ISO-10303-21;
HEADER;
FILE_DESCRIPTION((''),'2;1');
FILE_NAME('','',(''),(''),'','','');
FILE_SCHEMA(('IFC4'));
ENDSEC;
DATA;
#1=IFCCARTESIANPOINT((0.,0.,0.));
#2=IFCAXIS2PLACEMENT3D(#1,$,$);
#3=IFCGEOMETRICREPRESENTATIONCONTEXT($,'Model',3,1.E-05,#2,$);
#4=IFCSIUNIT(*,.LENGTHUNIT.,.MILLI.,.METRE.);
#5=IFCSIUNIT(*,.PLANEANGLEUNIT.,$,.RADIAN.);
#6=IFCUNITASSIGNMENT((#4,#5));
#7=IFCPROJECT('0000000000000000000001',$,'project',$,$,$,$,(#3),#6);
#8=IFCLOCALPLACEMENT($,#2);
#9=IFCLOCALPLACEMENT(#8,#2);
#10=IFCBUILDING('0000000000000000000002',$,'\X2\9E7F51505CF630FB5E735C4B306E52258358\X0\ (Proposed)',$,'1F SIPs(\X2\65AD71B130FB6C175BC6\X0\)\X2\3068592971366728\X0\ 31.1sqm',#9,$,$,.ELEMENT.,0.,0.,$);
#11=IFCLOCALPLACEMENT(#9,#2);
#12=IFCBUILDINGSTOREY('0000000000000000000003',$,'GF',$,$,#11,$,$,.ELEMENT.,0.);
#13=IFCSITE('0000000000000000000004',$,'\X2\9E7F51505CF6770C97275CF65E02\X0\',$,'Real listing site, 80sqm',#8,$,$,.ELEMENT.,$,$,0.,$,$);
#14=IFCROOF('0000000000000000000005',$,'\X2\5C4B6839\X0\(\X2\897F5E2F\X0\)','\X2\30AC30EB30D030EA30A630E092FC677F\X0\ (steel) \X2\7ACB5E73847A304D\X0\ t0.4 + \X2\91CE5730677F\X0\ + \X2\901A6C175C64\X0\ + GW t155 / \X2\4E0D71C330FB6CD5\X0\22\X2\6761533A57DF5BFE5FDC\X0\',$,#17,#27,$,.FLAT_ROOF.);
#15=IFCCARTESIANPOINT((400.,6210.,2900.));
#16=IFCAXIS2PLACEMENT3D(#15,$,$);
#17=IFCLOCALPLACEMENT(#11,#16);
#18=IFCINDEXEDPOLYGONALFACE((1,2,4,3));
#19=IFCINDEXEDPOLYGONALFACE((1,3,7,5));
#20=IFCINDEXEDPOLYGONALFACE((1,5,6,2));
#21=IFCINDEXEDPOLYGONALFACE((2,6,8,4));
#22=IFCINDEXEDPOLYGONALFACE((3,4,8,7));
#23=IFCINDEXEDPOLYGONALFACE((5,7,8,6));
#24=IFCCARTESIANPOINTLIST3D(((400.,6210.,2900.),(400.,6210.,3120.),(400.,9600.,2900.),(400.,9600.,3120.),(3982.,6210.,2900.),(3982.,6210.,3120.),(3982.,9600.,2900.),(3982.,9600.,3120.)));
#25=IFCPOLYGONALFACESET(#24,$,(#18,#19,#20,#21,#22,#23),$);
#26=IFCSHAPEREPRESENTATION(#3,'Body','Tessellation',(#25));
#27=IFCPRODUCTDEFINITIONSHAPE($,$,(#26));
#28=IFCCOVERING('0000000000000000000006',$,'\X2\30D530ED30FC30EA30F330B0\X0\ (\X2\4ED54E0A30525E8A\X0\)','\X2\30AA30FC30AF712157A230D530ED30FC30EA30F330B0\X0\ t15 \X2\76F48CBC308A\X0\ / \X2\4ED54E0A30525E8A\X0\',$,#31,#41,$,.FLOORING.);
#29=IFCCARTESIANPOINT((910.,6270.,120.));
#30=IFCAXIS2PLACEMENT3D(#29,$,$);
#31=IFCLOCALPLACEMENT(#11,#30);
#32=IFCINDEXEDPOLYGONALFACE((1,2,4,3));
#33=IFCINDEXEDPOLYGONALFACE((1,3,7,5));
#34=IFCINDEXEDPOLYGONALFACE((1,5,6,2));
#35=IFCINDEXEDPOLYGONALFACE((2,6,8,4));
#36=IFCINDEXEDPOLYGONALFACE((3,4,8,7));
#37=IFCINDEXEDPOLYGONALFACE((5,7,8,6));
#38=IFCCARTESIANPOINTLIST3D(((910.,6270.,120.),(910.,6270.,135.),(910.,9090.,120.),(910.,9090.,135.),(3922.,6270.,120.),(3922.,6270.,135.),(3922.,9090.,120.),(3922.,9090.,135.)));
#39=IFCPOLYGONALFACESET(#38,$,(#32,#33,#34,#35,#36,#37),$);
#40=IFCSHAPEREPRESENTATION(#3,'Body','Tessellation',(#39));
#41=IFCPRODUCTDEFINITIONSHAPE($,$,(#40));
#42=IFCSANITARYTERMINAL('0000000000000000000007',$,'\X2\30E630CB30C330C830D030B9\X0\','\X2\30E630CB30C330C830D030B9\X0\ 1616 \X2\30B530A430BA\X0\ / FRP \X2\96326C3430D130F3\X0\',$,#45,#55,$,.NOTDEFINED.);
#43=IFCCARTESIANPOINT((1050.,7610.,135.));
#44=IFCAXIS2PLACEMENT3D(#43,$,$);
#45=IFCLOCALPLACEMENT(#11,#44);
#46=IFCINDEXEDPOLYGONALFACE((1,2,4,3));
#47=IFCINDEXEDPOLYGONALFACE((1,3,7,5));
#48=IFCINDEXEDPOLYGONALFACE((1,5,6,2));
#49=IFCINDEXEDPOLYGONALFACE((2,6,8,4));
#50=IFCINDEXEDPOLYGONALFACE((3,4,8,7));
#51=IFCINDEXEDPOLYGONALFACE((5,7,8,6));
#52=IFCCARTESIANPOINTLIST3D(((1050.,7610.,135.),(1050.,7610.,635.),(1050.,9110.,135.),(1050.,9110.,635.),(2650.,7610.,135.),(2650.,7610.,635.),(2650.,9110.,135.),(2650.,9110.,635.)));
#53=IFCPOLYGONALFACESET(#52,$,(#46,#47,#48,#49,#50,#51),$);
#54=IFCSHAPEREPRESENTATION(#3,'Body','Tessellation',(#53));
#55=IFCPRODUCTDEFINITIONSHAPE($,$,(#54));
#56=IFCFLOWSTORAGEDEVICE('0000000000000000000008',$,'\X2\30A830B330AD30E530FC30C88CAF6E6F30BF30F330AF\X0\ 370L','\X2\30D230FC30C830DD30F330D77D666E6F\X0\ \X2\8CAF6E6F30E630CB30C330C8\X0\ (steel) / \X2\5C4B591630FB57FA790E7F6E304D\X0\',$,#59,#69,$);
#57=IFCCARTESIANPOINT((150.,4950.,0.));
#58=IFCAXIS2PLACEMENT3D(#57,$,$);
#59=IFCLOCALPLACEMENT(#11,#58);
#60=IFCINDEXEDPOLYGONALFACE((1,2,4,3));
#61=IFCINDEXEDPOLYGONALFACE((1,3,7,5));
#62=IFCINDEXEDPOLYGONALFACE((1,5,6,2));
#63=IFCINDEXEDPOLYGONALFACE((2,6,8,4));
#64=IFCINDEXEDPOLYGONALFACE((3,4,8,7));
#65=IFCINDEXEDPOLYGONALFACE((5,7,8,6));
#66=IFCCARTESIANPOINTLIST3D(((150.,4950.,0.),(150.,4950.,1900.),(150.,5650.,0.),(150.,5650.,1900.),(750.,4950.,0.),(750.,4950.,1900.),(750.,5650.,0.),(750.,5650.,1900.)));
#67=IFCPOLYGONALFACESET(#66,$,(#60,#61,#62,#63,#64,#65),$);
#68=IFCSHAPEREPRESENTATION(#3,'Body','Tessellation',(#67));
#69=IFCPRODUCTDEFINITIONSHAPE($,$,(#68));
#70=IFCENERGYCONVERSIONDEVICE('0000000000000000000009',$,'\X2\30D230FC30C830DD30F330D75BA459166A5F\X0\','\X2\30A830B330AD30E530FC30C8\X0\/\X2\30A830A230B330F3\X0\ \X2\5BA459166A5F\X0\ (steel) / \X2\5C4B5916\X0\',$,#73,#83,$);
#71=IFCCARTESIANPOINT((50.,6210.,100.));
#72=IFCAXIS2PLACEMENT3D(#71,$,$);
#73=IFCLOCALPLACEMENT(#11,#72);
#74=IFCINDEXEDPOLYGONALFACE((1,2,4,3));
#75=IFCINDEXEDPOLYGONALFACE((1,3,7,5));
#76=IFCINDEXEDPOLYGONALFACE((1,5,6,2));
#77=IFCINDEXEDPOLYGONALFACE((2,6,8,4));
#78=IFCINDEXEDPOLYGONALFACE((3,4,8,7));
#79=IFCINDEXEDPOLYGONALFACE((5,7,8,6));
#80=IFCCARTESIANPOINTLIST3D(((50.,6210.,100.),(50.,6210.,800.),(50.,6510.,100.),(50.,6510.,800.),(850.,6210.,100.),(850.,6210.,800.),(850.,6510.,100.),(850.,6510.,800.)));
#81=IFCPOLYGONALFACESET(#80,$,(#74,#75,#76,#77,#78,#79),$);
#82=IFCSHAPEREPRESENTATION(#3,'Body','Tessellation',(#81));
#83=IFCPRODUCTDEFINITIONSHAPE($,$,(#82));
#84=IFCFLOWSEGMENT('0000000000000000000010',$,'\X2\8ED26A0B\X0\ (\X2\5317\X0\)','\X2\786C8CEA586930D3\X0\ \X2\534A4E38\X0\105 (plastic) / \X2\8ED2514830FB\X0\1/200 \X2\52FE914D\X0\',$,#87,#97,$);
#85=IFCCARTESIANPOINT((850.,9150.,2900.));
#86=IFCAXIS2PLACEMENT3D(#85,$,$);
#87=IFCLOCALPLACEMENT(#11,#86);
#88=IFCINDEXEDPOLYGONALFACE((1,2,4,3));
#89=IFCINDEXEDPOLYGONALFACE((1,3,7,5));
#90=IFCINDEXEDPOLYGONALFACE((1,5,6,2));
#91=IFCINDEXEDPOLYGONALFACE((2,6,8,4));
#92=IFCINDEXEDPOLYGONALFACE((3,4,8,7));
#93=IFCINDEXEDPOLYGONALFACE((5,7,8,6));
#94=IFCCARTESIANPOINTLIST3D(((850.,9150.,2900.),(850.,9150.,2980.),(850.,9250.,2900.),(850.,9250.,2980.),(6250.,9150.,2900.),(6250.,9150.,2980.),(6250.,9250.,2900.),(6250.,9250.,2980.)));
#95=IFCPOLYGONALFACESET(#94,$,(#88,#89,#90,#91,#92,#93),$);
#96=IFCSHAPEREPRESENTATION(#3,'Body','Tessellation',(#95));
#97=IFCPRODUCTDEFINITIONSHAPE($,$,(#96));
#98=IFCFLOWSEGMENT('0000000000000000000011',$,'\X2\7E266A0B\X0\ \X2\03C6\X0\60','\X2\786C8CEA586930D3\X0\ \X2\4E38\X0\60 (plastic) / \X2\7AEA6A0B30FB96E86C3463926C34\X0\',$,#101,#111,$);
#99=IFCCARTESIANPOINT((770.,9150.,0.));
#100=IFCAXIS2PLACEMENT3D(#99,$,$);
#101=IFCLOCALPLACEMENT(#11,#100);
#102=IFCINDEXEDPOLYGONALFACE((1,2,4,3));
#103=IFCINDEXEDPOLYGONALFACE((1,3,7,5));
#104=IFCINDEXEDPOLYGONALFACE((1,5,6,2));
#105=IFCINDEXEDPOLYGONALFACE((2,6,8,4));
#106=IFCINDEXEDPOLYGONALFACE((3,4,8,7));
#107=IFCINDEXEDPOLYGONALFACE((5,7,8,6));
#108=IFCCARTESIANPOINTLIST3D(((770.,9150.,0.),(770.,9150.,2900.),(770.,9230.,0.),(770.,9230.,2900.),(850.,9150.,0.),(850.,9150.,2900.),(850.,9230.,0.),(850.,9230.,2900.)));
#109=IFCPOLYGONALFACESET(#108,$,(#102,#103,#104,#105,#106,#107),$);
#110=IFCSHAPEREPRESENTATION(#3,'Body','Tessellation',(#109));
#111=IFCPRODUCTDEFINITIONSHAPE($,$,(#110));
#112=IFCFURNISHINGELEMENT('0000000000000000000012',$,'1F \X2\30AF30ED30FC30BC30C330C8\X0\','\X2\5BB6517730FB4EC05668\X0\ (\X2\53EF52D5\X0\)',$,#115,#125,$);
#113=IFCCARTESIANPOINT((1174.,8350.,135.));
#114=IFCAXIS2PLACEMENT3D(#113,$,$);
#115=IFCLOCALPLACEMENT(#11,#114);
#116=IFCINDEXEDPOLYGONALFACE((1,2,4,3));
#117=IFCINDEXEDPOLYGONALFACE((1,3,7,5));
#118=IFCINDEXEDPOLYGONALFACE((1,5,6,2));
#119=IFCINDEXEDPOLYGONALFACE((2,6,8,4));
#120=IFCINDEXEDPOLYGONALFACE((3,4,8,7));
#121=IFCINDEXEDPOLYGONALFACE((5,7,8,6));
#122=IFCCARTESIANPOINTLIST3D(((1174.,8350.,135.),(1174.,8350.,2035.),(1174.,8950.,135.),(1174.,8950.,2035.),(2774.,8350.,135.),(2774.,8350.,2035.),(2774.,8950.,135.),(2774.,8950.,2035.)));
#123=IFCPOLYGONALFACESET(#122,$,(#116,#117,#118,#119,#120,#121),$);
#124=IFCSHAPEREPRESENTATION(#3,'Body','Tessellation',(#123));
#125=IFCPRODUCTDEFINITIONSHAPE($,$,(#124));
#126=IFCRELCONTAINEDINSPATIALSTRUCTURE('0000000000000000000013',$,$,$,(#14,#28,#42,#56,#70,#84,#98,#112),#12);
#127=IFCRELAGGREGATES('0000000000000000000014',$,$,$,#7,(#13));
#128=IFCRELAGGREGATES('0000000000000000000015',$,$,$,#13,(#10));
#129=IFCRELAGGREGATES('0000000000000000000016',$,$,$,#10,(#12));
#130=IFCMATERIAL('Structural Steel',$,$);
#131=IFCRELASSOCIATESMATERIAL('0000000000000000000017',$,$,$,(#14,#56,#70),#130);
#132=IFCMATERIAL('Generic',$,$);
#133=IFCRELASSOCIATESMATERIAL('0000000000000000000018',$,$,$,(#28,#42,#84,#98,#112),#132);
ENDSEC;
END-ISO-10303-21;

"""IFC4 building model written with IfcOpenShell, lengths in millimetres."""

from ifc_helpers import new_model, si_unit, frame, frame_2d, origin, place, context, project, spatial, rectangle, extrude, material, element, save


model = new_model("IFC4")

# Units and contexts
model_context = context("Model", 3, precision=1e-05, world=origin())
ifc_project = project(units=[si_unit("LENGTHUNIT", "METRE", prefix="MILLI"), si_unit("PLANEANGLEUNIT", "RADIAN")], contexts=[model_context])

# Site, building, storey
site_placement = place(None, origin())
site = spatial("IfcSite", under=ifc_project, at=site_placement, Name="鹿児島県霧島市", ObjectType="Real listing site, 80sqm", CompositionType="ELEMENT", RefElevation=0.0)
building_placement = place(site_placement, origin())
building = spatial("IfcBuilding", under=site, at=building_placement, Name="鹿児島・平屋の別荘 (Proposed)", ObjectType="1F SIPs(断熱・気密)と天然木 31.1sqm", CompositionType="ELEMENT", ElevationOfRefHeight=0.0, ElevationOfTerrain=0.0)
storey_placement = place(building_placement, origin())
storey = spatial("IfcBuildingStorey", under=building, at=storey_placement, Name="GF", CompositionType="ELEMENT", Elevation=0.0)

# Roof
ifc_material_1 = material(Name="Structural Steel")
roof_placement = place(storey_placement, frame((400.0, 6210.0, 2900.0)))
element("IfcRoof", 1, at=roof_placement, inside=storey, material=ifc_material_1, Name="屋根(西帯)", Description="ガルバリウム鋼板 (steel) 立平葺き t0.4 + 野地板 + 通気層 + GW t155 / 不燃・法22条区域対応", PredefinedType="FLAT_ROOF", context=model_context, shape_type="SweptSolid", body=[
    extrude(rectangle(XDim=3582.0, YDim=3390.0, at=frame_2d((1791.0, 1695.0))), frame((400.0, 6210.0, 2900.0)), (0.0, 0.0, 1.0), 220.0),
])

# Covering
ifc_material_2 = material(Name="Generic")
covering_placement = place(storey_placement, frame((910.0, 6270.0, 120.0)))
element("IfcCovering", 2, at=covering_placement, inside=storey, material=ifc_material_2, Name="フローリング (仕上げ床)", Description="オーク無垢フローリング t15 直貼り / 仕上げ床", PredefinedType="FLOORING", context=model_context, shape_type="SweptSolid", body=[
    extrude(rectangle(XDim=3012.0, YDim=2820.0, at=frame_2d((1506.0, 1410.0))), frame((910.0, 6270.0, 120.0)), (0.0, 0.0, 1.0), 15.0),
])

# Sanitary terminal
sanitary_terminal_placement = place(storey_placement, frame((1050.0, 7610.0, 135.0)))
element("IfcSanitaryTerminal", 3, at=sanitary_terminal_placement, inside=storey, material=ifc_material_2, Name="ユニットバス", Description="ユニットバス 1616 サイズ / FRP 防水パン", PredefinedType="NOTDEFINED", context=model_context, shape_type="SweptSolid", body=[
    extrude(rectangle(XDim=1600.0, YDim=1500.0, at=frame_2d((800.0, 750.0))), frame((1050.0, 7610.0, 135.0)), (0.0, 0.0, 1.0), 500.0),
])

# Flow storage device
flow_storage_device_placement = place(storey_placement, frame((150.0, 4950.0, 0.0)))
element("IfcFlowStorageDevice", 4, at=flow_storage_device_placement, inside=storey, material=ifc_material_1, Name="エコキュート貯湯タンク 370L", Description="ヒートポンプ給湯 貯湯ユニット (steel) / 屋外・基礎置き", context=model_context, shape_type="SweptSolid", body=[
    extrude(rectangle(XDim=600.0, YDim=700.0, at=frame_2d((300.0, 350.0))), frame((150.0, 4950.0, 0.0)), (0.0, 0.0, 1.0), 1900.0),
])

# Energy conversion device
energy_conversion_device_placement = place(storey_placement, frame((50.0, 6210.0, 100.0)))
element("IfcEnergyConversionDevice", 5, at=energy_conversion_device_placement, inside=storey, material=ifc_material_1, Name="ヒートポンプ室外機", Description="エコキュート/エアコン 室外機 (steel) / 屋外", context=model_context, shape_type="SweptSolid", body=[
    extrude(rectangle(XDim=800.0, YDim=300.0, at=frame_2d((400.0, 150.0))), frame((50.0, 6210.0, 100.0)), (0.0, 0.0, 1.0), 700.0),
])

# Flow segments
flow_segment_1_placement = place(storey_placement, frame((850.0, 9150.0, 2900.0)))
element("IfcFlowSegment", 6, at=flow_segment_1_placement, inside=storey, material=ifc_material_2, Name="軒樋 (北)", Description="硬質塩ビ 半丸105 (plastic) / 軒先・1/200 勾配", context=model_context, shape_type="SweptSolid", body=[
    extrude(rectangle(XDim=5400.0, YDim=100.0, at=frame_2d((2700.0, 50.0))), frame((850.0, 9150.0, 2900.0)), (0.0, 0.0, 1.0), 80.0),
])
flow_segment_2_placement = place(storey_placement, frame((770.0, 9150.0, 0.0)))
element("IfcFlowSegment", 7, at=flow_segment_2_placement, inside=storey, material=ifc_material_2, Name="縦樋 φ60", Description="硬質塩ビ 丸60 (plastic) / 竪樋・雨水排水", context=model_context, shape_type="SweptSolid", body=[
    extrude(rectangle(XDim=80.0, YDim=80.0, at=frame_2d((40.0, 40.0))), frame((770.0, 9150.0, 0.0)), (0.0, 0.0, 1.0), 2900.0),
])

# Furnishing element
furnishing_placement = place(storey_placement, frame((1174.0, 8350.0, 135.0)))
element("IfcFurnishingElement", 8, at=furnishing_placement, inside=storey, material=ifc_material_2, Name="1F クローゼット", Description="家具・什器 (可動)", context=model_context, shape_type="SweptSolid", body=[
    extrude(rectangle(XDim=1600.0, YDim=600.0, at=frame_2d((800.0, 300.0))), frame((1174.0, 8350.0, 135.0)), (0.0, 0.0, 1.0), 1900.0),
])

save(model, "model.ifc")
